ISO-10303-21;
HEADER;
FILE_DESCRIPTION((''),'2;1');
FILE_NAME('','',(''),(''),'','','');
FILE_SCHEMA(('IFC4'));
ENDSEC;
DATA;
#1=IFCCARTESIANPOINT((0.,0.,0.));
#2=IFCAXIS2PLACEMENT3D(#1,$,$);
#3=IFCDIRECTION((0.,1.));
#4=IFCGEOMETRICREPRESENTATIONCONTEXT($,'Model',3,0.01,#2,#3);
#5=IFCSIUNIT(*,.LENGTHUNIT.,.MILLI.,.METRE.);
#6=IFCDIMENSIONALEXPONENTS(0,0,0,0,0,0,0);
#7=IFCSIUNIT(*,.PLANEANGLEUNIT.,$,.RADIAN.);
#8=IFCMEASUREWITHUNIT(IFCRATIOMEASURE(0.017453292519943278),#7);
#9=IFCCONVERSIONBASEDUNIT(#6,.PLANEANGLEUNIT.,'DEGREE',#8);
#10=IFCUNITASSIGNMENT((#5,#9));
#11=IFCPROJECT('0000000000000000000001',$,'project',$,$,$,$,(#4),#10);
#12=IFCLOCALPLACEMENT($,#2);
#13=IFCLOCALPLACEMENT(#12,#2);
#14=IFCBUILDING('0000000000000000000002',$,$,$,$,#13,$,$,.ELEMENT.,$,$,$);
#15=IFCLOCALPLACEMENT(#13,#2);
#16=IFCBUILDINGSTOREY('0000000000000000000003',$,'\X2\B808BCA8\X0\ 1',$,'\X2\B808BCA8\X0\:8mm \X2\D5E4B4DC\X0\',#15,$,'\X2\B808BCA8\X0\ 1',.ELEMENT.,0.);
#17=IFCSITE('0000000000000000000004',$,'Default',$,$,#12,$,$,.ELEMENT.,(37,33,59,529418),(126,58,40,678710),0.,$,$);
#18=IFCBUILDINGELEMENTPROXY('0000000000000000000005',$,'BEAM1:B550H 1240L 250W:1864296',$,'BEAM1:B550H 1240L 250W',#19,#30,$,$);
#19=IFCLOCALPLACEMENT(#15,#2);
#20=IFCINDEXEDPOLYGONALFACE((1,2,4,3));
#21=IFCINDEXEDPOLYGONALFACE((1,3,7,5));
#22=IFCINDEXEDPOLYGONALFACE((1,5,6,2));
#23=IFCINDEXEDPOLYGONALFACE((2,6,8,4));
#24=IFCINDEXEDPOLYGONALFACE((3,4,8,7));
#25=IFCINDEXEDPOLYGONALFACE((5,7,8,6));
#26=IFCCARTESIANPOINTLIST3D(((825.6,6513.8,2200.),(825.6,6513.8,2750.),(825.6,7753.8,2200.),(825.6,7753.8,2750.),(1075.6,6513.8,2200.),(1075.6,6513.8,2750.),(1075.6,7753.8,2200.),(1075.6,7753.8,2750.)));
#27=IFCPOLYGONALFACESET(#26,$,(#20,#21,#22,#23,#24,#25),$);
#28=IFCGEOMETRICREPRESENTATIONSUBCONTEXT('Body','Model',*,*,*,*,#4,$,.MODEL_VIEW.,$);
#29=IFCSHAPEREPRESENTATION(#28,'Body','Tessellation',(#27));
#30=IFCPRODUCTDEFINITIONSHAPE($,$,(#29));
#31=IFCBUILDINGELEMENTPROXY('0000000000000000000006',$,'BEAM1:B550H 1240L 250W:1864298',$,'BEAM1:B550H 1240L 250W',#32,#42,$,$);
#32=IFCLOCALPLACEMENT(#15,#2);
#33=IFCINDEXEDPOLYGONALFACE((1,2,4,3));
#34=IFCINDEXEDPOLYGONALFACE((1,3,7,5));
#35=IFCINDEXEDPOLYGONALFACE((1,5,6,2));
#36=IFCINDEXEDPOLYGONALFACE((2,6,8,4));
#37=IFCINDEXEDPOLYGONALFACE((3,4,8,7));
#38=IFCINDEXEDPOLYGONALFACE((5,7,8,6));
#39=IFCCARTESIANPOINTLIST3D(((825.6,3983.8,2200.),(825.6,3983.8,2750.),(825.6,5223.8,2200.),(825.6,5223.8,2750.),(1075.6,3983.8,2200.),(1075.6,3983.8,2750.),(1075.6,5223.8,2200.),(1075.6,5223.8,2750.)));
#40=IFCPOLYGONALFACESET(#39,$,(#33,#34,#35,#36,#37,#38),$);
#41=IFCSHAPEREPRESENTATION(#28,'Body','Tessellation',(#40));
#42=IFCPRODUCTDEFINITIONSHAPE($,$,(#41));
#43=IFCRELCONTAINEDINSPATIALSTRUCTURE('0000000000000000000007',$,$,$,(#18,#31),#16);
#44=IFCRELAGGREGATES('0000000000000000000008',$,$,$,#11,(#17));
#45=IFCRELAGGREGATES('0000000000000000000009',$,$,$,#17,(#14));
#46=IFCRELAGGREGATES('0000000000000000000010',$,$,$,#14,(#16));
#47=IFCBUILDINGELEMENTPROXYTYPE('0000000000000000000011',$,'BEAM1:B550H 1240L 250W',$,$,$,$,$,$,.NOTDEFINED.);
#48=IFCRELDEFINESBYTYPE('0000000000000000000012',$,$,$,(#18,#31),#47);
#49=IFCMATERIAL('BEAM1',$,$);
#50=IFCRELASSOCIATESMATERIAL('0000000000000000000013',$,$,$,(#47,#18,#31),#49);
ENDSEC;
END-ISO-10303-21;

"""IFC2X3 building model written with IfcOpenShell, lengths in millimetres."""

from ifc_helpers import new_model, entity, si_unit, converted_unit, direction, frame, origin, origin_2d_with_axis, place, context, subcontext, project, spatial, rectangle, extrude, source, transform, mapped, material, type_object, type_shapes, element, save


model = new_model("IFC2X3")

# Units and contexts
model_context = context("Model", 3, precision=0.01, world=origin(), true_north=direction((0.0, 1.0)))
body_context = subcontext(model_context, "Body", "Model", "MODEL_VIEW")
ifc_project = project(units=[si_unit("LENGTHUNIT", "METRE", prefix="MILLI"), converted_unit("PLANEANGLEUNIT", "DEGREE", entity("IfcRatioMeasure", 0.017453292519943278), si_unit("PLANEANGLEUNIT", "RADIAN"), dimensions=[0, 0, 0, 0, 0, 0, 0])], contexts=[model_context])

# Site, building, storey
site_placement = place(None, origin())
site = spatial("IfcSite", under=ifc_project, at=site_placement, Name="Default", CompositionType="ELEMENT", RefLatitude=(37, 33, 59, 529418), RefLongitude=(126, 58, 40, 678710), RefElevation=0.0)
building_placement = place(site_placement, origin())
building = spatial("IfcBuilding", under=site, at=building_placement, CompositionType="ELEMENT")
storey_placement = place(building_placement, origin())
storey = spatial("IfcBuildingStorey", under=building, at=storey_placement, Name="레벨 1", ObjectType="레벨:8mm 헤드", LongName="레벨 1", CompositionType="ELEMENT", Elevation=0.0)

# Building element proxies
ifc_material_1 = material(Name="BEAM1")
building_element_proxy_type_1 = type_object("IfcBuildingElementProxyType", Name="BEAM1:B550H 1240L 250W", PredefinedType="NOTDEFINED", material=ifc_material_1)
shared_shape_1 = source(origin(), body_context, "Body", "SweptSolid", [
    extrude(rectangle(XDim=1240.0, YDim=250.0, at=origin_2d_with_axis()), frame((620.0, -125.0, -550.0)), (0.0, 0.0, 1.0), 550.0),
])
type_shapes(building_element_proxy_type_1, [shared_shape_1])
for number, where, z_axis, x_axis, name in (
    (1, (825.6, 6513.8, 2750.0), (0.0, 0.0, 1.0), (0.0, 1.0, 0.0), "BEAM1:B550H 1240L 250W:1864296"),
    (2, (825.6, 3983.8, 2750.0), (0.0, 0.0, 1.0), (0.0, 1.0, 0.0), "BEAM1:B550H 1240L 250W:1864298"),
):
    element("IfcBuildingElementProxy", number, at=place(storey_placement, frame(where, z_axis=z_axis, x_axis=x_axis)), inside=storey, type_object=building_element_proxy_type_1, material=ifc_material_1, Name=name, ObjectType="BEAM1:B550H 1240L 250W", context=body_context, shape_type="MappedRepresentation", body=[
        mapped(shared_shape_1, transform((0.0, 0.0, 0.0), scale=1.0)),
    ])

save(model, "model.ifc")
